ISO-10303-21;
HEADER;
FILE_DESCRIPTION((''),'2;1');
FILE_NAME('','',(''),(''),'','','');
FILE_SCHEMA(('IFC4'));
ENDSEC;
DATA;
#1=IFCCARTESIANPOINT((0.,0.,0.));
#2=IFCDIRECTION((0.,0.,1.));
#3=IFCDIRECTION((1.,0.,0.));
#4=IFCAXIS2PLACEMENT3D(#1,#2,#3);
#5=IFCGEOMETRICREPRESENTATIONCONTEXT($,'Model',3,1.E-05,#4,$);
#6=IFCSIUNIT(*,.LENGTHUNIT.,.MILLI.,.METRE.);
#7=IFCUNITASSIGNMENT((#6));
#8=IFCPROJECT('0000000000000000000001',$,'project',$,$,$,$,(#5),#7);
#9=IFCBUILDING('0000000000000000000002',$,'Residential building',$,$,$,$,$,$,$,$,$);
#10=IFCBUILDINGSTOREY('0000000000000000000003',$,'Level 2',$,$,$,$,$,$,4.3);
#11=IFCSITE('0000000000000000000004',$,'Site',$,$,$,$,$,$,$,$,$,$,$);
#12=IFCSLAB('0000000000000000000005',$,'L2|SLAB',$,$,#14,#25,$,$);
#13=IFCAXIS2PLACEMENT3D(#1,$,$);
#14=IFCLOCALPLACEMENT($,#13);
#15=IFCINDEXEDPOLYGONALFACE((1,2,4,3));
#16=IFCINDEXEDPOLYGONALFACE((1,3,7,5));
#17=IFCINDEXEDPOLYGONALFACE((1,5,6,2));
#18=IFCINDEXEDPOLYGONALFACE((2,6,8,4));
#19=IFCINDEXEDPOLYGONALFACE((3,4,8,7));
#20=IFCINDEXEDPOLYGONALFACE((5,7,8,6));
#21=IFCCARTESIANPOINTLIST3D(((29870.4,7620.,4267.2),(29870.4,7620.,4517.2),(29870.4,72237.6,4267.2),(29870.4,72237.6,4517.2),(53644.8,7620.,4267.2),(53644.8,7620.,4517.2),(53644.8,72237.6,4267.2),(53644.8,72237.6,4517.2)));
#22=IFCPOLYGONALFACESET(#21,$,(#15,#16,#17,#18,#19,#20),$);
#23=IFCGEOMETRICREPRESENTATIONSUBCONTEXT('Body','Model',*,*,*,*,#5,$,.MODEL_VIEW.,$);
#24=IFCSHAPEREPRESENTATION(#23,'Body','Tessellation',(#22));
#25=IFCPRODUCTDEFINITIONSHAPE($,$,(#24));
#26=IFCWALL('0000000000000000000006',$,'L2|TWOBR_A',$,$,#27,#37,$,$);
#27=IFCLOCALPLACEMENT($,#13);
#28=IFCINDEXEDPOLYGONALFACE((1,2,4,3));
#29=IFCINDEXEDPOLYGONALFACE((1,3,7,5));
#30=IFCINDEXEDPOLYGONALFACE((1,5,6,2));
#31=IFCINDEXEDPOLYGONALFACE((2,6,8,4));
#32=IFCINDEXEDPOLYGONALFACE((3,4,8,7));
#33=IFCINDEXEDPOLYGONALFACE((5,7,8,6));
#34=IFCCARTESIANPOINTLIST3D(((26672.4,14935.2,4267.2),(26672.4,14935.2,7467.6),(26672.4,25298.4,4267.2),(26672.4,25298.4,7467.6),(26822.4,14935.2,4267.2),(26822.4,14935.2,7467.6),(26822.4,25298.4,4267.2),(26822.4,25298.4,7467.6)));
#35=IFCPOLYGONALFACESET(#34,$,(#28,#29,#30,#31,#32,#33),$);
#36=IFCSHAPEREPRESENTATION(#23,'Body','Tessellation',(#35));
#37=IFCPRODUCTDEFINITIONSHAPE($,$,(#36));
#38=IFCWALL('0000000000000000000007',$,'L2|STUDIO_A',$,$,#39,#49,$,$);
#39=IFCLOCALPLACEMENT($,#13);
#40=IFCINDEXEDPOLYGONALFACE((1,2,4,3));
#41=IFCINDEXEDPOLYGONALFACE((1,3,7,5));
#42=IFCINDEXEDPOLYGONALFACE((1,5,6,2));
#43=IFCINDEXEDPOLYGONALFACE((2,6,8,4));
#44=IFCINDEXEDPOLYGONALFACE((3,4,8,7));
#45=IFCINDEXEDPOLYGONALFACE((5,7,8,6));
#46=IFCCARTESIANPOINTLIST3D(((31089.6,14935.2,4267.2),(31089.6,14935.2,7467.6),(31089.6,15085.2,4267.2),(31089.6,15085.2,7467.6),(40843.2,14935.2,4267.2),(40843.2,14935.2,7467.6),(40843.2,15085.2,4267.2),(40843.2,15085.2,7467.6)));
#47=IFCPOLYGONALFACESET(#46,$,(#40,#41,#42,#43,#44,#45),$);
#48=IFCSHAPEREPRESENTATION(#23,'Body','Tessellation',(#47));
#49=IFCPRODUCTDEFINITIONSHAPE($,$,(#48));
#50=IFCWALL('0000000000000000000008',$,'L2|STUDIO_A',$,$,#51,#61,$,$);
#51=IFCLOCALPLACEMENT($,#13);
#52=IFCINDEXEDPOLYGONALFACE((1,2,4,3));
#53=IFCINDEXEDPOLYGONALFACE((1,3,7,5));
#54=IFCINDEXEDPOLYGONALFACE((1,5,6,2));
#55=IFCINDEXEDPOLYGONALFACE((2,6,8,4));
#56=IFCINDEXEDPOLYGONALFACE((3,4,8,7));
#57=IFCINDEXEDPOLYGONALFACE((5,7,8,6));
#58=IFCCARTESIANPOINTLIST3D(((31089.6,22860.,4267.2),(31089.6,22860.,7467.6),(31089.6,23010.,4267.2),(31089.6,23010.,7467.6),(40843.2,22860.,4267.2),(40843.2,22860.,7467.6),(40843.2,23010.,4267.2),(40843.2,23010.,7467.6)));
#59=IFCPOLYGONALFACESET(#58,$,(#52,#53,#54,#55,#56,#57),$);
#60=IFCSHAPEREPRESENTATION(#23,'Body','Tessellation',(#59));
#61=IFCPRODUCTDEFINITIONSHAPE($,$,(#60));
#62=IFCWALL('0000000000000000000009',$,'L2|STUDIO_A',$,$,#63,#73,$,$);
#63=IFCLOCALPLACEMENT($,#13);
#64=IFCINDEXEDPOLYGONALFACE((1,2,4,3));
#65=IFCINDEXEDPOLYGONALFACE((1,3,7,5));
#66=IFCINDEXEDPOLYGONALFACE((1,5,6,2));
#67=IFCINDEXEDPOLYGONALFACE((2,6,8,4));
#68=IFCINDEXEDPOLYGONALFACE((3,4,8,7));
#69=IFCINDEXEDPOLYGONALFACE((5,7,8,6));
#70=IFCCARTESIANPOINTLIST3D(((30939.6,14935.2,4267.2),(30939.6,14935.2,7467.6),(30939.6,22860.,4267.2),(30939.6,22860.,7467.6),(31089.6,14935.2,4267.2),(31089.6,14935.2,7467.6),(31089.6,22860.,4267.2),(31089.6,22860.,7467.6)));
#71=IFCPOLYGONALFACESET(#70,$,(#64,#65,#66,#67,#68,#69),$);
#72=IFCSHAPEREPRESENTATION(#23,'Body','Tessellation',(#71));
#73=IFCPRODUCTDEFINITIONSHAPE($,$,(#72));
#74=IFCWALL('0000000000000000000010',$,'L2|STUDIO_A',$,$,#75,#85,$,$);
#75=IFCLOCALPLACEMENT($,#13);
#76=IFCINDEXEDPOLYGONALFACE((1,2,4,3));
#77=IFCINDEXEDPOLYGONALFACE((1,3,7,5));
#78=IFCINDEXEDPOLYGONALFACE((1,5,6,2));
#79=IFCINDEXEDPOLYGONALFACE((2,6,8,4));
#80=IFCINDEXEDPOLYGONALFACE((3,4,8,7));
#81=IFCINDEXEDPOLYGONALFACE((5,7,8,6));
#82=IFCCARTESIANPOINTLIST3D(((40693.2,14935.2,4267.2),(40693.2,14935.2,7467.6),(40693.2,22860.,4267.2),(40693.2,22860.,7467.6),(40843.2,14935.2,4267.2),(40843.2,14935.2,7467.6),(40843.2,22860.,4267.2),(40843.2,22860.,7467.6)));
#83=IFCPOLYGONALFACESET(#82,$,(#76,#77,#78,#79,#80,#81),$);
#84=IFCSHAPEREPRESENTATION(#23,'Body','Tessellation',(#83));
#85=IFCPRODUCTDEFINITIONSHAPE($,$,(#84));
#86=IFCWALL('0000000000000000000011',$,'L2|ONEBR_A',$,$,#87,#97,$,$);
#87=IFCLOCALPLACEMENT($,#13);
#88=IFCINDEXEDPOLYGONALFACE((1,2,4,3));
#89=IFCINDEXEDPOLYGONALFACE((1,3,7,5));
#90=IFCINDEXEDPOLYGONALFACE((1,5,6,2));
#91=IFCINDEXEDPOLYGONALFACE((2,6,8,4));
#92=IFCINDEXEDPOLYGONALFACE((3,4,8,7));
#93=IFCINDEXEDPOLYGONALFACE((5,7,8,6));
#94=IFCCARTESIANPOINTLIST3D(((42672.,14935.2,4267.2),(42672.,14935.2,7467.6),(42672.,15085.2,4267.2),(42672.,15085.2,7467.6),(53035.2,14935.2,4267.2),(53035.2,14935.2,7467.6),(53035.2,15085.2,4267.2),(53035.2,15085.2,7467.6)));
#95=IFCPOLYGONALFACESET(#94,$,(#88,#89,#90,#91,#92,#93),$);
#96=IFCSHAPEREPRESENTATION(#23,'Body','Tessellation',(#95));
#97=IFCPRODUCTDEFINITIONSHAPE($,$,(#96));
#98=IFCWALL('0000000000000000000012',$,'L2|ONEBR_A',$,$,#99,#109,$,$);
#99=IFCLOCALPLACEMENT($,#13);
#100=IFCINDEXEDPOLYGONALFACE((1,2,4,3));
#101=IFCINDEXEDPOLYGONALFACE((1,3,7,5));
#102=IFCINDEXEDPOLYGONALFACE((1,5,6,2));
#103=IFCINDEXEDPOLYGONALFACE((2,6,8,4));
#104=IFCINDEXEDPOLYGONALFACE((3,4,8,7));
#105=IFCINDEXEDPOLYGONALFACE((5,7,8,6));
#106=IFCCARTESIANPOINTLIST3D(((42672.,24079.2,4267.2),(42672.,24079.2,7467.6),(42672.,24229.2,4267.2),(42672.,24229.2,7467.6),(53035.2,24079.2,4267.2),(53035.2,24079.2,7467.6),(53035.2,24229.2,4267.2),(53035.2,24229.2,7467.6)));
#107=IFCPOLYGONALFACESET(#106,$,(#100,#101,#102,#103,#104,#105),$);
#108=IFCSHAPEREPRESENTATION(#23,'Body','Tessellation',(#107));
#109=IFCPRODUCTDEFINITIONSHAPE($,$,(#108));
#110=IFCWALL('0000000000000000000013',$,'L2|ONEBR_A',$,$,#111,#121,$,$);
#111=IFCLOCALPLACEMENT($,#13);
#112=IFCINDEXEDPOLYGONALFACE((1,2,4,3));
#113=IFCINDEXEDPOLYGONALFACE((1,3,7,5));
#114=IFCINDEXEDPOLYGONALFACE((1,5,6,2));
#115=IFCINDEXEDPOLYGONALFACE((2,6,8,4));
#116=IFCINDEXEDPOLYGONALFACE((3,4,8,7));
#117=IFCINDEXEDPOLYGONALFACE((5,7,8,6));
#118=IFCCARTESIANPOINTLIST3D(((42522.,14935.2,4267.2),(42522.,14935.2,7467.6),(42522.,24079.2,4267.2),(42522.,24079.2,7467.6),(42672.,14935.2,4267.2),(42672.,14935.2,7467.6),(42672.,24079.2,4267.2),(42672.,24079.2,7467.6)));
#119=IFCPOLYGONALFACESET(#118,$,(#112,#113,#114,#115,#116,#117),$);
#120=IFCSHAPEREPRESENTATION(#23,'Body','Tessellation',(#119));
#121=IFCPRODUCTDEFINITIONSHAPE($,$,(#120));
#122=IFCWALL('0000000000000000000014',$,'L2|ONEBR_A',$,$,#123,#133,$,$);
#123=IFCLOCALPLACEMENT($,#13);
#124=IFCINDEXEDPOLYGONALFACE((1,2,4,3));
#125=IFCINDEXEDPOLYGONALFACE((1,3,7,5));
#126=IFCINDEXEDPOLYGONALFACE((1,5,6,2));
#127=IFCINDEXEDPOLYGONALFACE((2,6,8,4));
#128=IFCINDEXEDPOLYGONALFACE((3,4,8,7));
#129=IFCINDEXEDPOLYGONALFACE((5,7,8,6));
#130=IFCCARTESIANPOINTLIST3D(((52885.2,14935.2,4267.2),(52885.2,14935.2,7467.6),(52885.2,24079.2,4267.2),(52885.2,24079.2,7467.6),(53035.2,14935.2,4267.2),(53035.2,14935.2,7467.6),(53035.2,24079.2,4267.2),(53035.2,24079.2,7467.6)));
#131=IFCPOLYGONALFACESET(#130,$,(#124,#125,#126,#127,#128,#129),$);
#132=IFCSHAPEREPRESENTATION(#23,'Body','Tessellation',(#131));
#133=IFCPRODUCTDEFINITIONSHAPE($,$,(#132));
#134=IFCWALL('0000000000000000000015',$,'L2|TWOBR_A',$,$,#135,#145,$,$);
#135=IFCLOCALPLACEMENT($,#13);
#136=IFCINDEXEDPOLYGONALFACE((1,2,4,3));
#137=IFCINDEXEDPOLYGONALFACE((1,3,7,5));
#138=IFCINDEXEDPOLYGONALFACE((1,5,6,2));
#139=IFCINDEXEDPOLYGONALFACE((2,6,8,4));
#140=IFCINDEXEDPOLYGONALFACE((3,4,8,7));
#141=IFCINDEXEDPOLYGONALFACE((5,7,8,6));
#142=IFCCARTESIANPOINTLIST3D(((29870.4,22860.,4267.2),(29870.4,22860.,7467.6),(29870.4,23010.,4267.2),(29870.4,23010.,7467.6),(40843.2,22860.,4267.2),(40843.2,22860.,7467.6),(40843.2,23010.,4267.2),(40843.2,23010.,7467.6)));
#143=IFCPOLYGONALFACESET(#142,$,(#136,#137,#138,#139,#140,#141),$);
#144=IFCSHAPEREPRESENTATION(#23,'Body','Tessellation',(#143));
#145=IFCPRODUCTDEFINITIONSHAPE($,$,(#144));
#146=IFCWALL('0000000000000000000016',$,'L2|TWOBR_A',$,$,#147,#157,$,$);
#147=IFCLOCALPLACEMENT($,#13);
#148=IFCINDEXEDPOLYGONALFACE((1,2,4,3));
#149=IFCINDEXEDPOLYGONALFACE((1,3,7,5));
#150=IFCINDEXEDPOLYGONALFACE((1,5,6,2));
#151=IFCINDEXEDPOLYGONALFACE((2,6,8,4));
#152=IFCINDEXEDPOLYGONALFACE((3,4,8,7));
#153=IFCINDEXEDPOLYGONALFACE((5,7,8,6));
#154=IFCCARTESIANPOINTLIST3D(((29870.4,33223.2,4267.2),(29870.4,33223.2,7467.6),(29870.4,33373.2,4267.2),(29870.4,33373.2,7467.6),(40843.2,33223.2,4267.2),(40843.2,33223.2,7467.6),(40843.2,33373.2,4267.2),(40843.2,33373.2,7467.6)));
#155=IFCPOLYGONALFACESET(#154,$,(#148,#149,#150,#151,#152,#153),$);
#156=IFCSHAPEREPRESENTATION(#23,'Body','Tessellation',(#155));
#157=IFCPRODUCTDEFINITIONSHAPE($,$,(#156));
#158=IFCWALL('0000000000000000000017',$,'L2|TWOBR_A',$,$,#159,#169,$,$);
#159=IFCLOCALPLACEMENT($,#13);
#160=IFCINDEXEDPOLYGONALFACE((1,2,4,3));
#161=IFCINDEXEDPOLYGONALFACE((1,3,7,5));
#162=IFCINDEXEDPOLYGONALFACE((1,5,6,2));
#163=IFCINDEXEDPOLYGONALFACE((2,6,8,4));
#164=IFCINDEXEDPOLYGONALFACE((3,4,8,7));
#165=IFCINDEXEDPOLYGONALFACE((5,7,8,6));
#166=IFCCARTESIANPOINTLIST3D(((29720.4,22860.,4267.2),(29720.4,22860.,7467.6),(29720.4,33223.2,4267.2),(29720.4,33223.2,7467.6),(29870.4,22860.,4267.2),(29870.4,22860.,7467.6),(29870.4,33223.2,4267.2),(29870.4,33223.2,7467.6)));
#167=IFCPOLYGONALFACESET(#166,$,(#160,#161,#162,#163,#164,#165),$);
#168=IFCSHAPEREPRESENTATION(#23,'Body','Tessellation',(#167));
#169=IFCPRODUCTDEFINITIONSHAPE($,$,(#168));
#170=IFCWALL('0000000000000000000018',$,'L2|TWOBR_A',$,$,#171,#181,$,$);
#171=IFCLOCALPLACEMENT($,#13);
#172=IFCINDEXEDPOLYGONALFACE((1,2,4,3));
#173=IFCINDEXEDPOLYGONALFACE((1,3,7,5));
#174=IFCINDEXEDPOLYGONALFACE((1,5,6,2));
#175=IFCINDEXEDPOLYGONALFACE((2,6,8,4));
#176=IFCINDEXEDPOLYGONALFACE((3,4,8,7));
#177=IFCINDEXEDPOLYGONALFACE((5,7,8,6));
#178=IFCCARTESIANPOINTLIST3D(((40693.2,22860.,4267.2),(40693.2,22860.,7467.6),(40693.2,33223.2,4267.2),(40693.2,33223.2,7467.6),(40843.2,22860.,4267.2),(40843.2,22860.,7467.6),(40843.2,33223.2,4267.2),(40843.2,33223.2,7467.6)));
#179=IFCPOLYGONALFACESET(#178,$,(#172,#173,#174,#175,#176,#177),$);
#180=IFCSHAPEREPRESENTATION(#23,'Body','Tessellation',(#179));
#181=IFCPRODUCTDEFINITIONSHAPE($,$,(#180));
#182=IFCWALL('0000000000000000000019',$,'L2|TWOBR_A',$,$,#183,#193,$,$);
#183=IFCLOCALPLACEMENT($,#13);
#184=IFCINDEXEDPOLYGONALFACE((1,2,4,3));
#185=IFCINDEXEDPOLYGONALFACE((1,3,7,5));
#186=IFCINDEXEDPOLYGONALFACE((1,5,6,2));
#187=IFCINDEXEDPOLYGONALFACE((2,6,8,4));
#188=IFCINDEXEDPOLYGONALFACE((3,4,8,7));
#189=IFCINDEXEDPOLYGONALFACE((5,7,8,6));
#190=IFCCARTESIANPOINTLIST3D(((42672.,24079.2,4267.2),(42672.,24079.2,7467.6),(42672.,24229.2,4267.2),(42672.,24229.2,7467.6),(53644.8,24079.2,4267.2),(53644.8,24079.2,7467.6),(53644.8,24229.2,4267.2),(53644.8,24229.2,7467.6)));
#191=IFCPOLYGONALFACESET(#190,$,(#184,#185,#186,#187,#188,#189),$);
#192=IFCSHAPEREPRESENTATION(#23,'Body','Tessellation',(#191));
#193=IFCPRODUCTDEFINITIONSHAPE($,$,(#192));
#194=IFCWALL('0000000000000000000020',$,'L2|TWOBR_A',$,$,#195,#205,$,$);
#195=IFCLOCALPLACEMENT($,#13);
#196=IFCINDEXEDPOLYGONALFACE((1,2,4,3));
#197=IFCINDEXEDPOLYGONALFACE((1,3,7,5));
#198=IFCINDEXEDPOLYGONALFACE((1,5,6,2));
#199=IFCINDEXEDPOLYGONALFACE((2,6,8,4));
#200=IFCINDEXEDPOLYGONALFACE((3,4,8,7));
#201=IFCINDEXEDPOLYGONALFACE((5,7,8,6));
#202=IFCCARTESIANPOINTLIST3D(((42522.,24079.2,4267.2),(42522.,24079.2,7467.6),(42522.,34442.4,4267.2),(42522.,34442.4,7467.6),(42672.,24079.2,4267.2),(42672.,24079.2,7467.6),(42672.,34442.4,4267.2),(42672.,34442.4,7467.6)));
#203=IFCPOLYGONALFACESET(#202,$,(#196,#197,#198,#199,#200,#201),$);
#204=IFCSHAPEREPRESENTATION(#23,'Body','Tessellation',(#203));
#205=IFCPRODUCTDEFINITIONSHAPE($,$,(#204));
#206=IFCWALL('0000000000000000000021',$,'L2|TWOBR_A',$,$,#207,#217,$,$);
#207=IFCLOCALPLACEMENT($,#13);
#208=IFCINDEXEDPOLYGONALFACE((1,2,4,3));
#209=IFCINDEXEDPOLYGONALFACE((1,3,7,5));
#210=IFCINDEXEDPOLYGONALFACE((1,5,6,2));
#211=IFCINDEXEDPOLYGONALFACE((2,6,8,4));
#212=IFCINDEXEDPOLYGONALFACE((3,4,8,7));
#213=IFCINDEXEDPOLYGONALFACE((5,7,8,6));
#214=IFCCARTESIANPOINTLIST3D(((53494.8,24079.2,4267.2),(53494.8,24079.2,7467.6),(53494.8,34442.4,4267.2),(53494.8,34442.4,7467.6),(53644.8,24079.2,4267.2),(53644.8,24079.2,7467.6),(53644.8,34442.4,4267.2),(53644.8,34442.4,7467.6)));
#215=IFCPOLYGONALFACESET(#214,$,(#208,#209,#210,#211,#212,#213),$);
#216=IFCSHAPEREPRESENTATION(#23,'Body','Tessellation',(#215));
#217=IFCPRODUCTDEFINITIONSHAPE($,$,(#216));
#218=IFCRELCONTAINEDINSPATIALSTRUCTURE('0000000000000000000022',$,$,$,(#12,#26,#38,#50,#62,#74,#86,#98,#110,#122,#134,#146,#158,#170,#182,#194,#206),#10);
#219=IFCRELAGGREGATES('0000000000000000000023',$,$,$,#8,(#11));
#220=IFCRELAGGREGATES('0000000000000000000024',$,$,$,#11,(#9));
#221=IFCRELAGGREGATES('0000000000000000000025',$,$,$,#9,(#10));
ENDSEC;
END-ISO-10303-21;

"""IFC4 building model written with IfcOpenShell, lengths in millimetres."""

from ifc_helpers import new_model, si_unit, frame, origin_with_axes, place, context, subcontext, project, spatial, indexed_curve, outline, extrude, element, save


model = new_model("IFC4")

# Units and contexts
model_context = context("Model", 3, precision=1e-05, world=origin_with_axes())
body_context = subcontext(model_context, "Body", "Model", "MODEL_VIEW")
ifc_project = project(units=[si_unit("LENGTHUNIT", "METRE", prefix="MILLI")], contexts=[model_context])

# Site, building, storey
site = spatial("IfcSite", under=ifc_project, Name="Site")
building = spatial("IfcBuilding", under=site, Name="Residential building")
storey = spatial("IfcBuildingStorey", under=building, Name="Level 2", Elevation=4.3)

# Slab
slab_placement = place(None, frame((29870.4, 7620.0, 4267.2), z_axis=(0.0, 0.0, 1.0), x_axis=(1.0, 0.0, 0.0)))
element("IfcSlab", 1, at=slab_placement, inside=storey, Name="L2|SLAB", context=body_context, shape_type="SweptSolid", body=[
    extrude(outline(indexed_curve([(0.0, 0.0), (23774.4, 0.0), (23774.4, 64617.6), (0.0, 64617.6), (0.0, 0.0)])), None, (0.0, 0.0, 1.0), 250.0),
])

# Walls
wall_1_placement = place(None, frame((26822.4, 14935.2, 4267.2), z_axis=(0.0, 0.0, 1.0), x_axis=(0.0, 1.0, 0.0)))
element("IfcWall", 2, at=wall_1_placement, inside=storey, Name="L2|TWOBR_A", context=body_context, shape_type="SweptSolid", body=[
    extrude(outline(indexed_curve([(0.0, 0.0), (0.0, 150.0), (10363.2, 150.0), (10363.2, 0.0), (0.0, 0.0)], self_intersect=False)), origin_with_axes(), (0.0, 0.0, 1.0), 3200.4),
])
for number, where, z_axis, x_axis, name in (
    (3, (31089.6, 14935.2, 4267.2), (0.0, 0.0, 1.0), (1.0, 0.0, 0.0), "L2|STUDIO_A"),
    (4, (31089.6, 22860.0, 4267.2), (0.0, 0.0, 1.0), (1.0, 0.0, 0.0), "L2|STUDIO_A"),
):
    element("IfcWall", number, at=place(None, frame(where, z_axis=z_axis, x_axis=x_axis)), inside=storey, Name=name, context=body_context, shape_type="SweptSolid", body=[
        extrude(outline(indexed_curve([(0.0, 0.0), (0.0, 150.0), (9753.6, 150.0), (9753.6, 0.0), (0.0, 0.0)], self_intersect=False)), origin_with_axes(), (0.0, 0.0, 1.0), 3200.4),
    ])
for number, where, z_axis, x_axis, name in (
    (5, (31089.6, 14935.2, 4267.2), (0.0, 0.0, 1.0), (0.0, 1.0, 0.0), "L2|STUDIO_A"),
    (6, (40843.2, 14935.2, 4267.2), (0.0, 0.0, 1.0), (0.0, 1.0, 0.0), "L2|STUDIO_A"),
):
    element("IfcWall", number, at=place(None, frame(where, z_axis=z_axis, x_axis=x_axis)), inside=storey, Name=name, context=body_context, shape_type="SweptSolid", body=[
        extrude(outline(indexed_curve([(0.0, 0.0), (0.0, 150.0), (7924.8, 150.0), (7924.8, 0.0), (0.0, 0.0)], self_intersect=False)), origin_with_axes(), (0.0, 0.0, 1.0), 3200.4),
    ])
for number, where, z_axis, x_axis, name in (
    (7, (42672.0, 14935.2, 4267.2), (0.0, 0.0, 1.0), (1.0, 0.0, 0.0), "L2|ONEBR_A"),
    (8, (42672.0, 24079.2, 4267.2), (0.0, 0.0, 1.0), (1.0, 0.0, 0.0), "L2|ONEBR_A"),
):
    element("IfcWall", number, at=place(None, frame(where, z_axis=z_axis, x_axis=x_axis)), inside=storey, Name=name, context=body_context, shape_type="SweptSolid", body=[
        extrude(outline(indexed_curve([(0.0, 0.0), (0.0, 150.0), (10363.2, 150.0), (10363.2, 0.0), (0.0, 0.0)], self_intersect=False)), origin_with_axes(), (0.0, 0.0, 1.0), 3200.4),
    ])
for number, where, z_axis, x_axis, name in (
    (9, (42672.0, 14935.2, 4267.2), (0.0, 0.0, 1.0), (0.0, 1.0, 0.0), "L2|ONEBR_A"),
    (10, (53035.2, 14935.2, 4267.2), (0.0, 0.0, 1.0), (0.0, 1.0, 0.0), "L2|ONEBR_A"),
):
    element("IfcWall", number, at=place(None, frame(where, z_axis=z_axis, x_axis=x_axis)), inside=storey, Name=name, context=body_context, shape_type="SweptSolid", body=[
        extrude(outline(indexed_curve([(0.0, 0.0), (0.0, 150.0), (9144.0, 150.0), (9144.0, 0.0), (0.0, 0.0)], self_intersect=False)), origin_with_axes(), (0.0, 0.0, 1.0), 3200.4),
    ])
for number, where, z_axis, x_axis, name in (
    (11, (29870.4, 22860.0, 4267.2), (0.0, 0.0, 1.0), (1.0, 0.0, 0.0), "L2|TWOBR_A"),
    (12, (29870.4, 33223.2, 4267.2), (0.0, 0.0, 1.0), (1.0, 0.0, 0.0), "L2|TWOBR_A"),
):
    element("IfcWall", number, at=place(None, frame(where, z_axis=z_axis, x_axis=x_axis)), inside=storey, Name=name, context=body_context, shape_type="SweptSolid", body=[
        extrude(outline(indexed_curve([(0.0, 0.0), (0.0, 150.0), (10972.8, 150.0), (10972.8, 0.0), (0.0, 0.0)], self_intersect=False)), origin_with_axes(), (0.0, 0.0, 1.0), 3200.4),
    ])
for number, where, z_axis, x_axis, name in (
    (13, (29870.4, 22860.0, 4267.2), (0.0, 0.0, 1.0), (0.0, 1.0, 0.0), "L2|TWOBR_A"),
    (14, (40843.2, 22860.0, 4267.2), (0.0, 0.0, 1.0), (0.0, 1.0, 0.0), "L2|TWOBR_A"),
):
    element("IfcWall", number, at=place(None, frame(where, z_axis=z_axis, x_axis=x_axis)), inside=storey, Name=name, context=body_context, shape_type="SweptSolid", body=[
        extrude(outline(indexed_curve([(0.0, 0.0), (0.0, 150.0), (10363.2, 150.0), (10363.2, 0.0), (0.0, 0.0)], self_intersect=False)), origin_with_axes(), (0.0, 0.0, 1.0), 3200.4),
    ])
wall_2_placement = place(None, frame((42672.0, 24079.2, 4267.2), z_axis=(0.0, 0.0, 1.0), x_axis=(1.0, 0.0, 0.0)))
element("IfcWall", 15, at=wall_2_placement, inside=storey, Name="L2|TWOBR_A", context=body_context, shape_type="SweptSolid", body=[
    extrude(outline(indexed_curve([(0.0, 0.0), (0.0, 150.0), (10972.8, 150.0), (10972.8, 0.0), (0.0, 0.0)], self_intersect=False)), origin_with_axes(), (0.0, 0.0, 1.0), 3200.4),
])
for number, where, z_axis, x_axis, name in (
    (16, (42672.0, 24079.2, 4267.2), (0.0, 0.0, 1.0), (0.0, 1.0, 0.0), "L2|TWOBR_A"),
    (17, (53644.8, 24079.2, 4267.2), (0.0, 0.0, 1.0), (0.0, 1.0, 0.0), "L2|TWOBR_A"),
):
    element("IfcWall", number, at=place(None, frame(where, z_axis=z_axis, x_axis=x_axis)), inside=storey, Name=name, context=body_context, shape_type="SweptSolid", body=[
        extrude(outline(indexed_curve([(0.0, 0.0), (0.0, 150.0), (10363.2, 150.0), (10363.2, 0.0), (0.0, 0.0)], self_intersect=False)), origin_with_axes(), (0.0, 0.0, 1.0), 3200.4),
    ])

save(model, "model.ifc")
